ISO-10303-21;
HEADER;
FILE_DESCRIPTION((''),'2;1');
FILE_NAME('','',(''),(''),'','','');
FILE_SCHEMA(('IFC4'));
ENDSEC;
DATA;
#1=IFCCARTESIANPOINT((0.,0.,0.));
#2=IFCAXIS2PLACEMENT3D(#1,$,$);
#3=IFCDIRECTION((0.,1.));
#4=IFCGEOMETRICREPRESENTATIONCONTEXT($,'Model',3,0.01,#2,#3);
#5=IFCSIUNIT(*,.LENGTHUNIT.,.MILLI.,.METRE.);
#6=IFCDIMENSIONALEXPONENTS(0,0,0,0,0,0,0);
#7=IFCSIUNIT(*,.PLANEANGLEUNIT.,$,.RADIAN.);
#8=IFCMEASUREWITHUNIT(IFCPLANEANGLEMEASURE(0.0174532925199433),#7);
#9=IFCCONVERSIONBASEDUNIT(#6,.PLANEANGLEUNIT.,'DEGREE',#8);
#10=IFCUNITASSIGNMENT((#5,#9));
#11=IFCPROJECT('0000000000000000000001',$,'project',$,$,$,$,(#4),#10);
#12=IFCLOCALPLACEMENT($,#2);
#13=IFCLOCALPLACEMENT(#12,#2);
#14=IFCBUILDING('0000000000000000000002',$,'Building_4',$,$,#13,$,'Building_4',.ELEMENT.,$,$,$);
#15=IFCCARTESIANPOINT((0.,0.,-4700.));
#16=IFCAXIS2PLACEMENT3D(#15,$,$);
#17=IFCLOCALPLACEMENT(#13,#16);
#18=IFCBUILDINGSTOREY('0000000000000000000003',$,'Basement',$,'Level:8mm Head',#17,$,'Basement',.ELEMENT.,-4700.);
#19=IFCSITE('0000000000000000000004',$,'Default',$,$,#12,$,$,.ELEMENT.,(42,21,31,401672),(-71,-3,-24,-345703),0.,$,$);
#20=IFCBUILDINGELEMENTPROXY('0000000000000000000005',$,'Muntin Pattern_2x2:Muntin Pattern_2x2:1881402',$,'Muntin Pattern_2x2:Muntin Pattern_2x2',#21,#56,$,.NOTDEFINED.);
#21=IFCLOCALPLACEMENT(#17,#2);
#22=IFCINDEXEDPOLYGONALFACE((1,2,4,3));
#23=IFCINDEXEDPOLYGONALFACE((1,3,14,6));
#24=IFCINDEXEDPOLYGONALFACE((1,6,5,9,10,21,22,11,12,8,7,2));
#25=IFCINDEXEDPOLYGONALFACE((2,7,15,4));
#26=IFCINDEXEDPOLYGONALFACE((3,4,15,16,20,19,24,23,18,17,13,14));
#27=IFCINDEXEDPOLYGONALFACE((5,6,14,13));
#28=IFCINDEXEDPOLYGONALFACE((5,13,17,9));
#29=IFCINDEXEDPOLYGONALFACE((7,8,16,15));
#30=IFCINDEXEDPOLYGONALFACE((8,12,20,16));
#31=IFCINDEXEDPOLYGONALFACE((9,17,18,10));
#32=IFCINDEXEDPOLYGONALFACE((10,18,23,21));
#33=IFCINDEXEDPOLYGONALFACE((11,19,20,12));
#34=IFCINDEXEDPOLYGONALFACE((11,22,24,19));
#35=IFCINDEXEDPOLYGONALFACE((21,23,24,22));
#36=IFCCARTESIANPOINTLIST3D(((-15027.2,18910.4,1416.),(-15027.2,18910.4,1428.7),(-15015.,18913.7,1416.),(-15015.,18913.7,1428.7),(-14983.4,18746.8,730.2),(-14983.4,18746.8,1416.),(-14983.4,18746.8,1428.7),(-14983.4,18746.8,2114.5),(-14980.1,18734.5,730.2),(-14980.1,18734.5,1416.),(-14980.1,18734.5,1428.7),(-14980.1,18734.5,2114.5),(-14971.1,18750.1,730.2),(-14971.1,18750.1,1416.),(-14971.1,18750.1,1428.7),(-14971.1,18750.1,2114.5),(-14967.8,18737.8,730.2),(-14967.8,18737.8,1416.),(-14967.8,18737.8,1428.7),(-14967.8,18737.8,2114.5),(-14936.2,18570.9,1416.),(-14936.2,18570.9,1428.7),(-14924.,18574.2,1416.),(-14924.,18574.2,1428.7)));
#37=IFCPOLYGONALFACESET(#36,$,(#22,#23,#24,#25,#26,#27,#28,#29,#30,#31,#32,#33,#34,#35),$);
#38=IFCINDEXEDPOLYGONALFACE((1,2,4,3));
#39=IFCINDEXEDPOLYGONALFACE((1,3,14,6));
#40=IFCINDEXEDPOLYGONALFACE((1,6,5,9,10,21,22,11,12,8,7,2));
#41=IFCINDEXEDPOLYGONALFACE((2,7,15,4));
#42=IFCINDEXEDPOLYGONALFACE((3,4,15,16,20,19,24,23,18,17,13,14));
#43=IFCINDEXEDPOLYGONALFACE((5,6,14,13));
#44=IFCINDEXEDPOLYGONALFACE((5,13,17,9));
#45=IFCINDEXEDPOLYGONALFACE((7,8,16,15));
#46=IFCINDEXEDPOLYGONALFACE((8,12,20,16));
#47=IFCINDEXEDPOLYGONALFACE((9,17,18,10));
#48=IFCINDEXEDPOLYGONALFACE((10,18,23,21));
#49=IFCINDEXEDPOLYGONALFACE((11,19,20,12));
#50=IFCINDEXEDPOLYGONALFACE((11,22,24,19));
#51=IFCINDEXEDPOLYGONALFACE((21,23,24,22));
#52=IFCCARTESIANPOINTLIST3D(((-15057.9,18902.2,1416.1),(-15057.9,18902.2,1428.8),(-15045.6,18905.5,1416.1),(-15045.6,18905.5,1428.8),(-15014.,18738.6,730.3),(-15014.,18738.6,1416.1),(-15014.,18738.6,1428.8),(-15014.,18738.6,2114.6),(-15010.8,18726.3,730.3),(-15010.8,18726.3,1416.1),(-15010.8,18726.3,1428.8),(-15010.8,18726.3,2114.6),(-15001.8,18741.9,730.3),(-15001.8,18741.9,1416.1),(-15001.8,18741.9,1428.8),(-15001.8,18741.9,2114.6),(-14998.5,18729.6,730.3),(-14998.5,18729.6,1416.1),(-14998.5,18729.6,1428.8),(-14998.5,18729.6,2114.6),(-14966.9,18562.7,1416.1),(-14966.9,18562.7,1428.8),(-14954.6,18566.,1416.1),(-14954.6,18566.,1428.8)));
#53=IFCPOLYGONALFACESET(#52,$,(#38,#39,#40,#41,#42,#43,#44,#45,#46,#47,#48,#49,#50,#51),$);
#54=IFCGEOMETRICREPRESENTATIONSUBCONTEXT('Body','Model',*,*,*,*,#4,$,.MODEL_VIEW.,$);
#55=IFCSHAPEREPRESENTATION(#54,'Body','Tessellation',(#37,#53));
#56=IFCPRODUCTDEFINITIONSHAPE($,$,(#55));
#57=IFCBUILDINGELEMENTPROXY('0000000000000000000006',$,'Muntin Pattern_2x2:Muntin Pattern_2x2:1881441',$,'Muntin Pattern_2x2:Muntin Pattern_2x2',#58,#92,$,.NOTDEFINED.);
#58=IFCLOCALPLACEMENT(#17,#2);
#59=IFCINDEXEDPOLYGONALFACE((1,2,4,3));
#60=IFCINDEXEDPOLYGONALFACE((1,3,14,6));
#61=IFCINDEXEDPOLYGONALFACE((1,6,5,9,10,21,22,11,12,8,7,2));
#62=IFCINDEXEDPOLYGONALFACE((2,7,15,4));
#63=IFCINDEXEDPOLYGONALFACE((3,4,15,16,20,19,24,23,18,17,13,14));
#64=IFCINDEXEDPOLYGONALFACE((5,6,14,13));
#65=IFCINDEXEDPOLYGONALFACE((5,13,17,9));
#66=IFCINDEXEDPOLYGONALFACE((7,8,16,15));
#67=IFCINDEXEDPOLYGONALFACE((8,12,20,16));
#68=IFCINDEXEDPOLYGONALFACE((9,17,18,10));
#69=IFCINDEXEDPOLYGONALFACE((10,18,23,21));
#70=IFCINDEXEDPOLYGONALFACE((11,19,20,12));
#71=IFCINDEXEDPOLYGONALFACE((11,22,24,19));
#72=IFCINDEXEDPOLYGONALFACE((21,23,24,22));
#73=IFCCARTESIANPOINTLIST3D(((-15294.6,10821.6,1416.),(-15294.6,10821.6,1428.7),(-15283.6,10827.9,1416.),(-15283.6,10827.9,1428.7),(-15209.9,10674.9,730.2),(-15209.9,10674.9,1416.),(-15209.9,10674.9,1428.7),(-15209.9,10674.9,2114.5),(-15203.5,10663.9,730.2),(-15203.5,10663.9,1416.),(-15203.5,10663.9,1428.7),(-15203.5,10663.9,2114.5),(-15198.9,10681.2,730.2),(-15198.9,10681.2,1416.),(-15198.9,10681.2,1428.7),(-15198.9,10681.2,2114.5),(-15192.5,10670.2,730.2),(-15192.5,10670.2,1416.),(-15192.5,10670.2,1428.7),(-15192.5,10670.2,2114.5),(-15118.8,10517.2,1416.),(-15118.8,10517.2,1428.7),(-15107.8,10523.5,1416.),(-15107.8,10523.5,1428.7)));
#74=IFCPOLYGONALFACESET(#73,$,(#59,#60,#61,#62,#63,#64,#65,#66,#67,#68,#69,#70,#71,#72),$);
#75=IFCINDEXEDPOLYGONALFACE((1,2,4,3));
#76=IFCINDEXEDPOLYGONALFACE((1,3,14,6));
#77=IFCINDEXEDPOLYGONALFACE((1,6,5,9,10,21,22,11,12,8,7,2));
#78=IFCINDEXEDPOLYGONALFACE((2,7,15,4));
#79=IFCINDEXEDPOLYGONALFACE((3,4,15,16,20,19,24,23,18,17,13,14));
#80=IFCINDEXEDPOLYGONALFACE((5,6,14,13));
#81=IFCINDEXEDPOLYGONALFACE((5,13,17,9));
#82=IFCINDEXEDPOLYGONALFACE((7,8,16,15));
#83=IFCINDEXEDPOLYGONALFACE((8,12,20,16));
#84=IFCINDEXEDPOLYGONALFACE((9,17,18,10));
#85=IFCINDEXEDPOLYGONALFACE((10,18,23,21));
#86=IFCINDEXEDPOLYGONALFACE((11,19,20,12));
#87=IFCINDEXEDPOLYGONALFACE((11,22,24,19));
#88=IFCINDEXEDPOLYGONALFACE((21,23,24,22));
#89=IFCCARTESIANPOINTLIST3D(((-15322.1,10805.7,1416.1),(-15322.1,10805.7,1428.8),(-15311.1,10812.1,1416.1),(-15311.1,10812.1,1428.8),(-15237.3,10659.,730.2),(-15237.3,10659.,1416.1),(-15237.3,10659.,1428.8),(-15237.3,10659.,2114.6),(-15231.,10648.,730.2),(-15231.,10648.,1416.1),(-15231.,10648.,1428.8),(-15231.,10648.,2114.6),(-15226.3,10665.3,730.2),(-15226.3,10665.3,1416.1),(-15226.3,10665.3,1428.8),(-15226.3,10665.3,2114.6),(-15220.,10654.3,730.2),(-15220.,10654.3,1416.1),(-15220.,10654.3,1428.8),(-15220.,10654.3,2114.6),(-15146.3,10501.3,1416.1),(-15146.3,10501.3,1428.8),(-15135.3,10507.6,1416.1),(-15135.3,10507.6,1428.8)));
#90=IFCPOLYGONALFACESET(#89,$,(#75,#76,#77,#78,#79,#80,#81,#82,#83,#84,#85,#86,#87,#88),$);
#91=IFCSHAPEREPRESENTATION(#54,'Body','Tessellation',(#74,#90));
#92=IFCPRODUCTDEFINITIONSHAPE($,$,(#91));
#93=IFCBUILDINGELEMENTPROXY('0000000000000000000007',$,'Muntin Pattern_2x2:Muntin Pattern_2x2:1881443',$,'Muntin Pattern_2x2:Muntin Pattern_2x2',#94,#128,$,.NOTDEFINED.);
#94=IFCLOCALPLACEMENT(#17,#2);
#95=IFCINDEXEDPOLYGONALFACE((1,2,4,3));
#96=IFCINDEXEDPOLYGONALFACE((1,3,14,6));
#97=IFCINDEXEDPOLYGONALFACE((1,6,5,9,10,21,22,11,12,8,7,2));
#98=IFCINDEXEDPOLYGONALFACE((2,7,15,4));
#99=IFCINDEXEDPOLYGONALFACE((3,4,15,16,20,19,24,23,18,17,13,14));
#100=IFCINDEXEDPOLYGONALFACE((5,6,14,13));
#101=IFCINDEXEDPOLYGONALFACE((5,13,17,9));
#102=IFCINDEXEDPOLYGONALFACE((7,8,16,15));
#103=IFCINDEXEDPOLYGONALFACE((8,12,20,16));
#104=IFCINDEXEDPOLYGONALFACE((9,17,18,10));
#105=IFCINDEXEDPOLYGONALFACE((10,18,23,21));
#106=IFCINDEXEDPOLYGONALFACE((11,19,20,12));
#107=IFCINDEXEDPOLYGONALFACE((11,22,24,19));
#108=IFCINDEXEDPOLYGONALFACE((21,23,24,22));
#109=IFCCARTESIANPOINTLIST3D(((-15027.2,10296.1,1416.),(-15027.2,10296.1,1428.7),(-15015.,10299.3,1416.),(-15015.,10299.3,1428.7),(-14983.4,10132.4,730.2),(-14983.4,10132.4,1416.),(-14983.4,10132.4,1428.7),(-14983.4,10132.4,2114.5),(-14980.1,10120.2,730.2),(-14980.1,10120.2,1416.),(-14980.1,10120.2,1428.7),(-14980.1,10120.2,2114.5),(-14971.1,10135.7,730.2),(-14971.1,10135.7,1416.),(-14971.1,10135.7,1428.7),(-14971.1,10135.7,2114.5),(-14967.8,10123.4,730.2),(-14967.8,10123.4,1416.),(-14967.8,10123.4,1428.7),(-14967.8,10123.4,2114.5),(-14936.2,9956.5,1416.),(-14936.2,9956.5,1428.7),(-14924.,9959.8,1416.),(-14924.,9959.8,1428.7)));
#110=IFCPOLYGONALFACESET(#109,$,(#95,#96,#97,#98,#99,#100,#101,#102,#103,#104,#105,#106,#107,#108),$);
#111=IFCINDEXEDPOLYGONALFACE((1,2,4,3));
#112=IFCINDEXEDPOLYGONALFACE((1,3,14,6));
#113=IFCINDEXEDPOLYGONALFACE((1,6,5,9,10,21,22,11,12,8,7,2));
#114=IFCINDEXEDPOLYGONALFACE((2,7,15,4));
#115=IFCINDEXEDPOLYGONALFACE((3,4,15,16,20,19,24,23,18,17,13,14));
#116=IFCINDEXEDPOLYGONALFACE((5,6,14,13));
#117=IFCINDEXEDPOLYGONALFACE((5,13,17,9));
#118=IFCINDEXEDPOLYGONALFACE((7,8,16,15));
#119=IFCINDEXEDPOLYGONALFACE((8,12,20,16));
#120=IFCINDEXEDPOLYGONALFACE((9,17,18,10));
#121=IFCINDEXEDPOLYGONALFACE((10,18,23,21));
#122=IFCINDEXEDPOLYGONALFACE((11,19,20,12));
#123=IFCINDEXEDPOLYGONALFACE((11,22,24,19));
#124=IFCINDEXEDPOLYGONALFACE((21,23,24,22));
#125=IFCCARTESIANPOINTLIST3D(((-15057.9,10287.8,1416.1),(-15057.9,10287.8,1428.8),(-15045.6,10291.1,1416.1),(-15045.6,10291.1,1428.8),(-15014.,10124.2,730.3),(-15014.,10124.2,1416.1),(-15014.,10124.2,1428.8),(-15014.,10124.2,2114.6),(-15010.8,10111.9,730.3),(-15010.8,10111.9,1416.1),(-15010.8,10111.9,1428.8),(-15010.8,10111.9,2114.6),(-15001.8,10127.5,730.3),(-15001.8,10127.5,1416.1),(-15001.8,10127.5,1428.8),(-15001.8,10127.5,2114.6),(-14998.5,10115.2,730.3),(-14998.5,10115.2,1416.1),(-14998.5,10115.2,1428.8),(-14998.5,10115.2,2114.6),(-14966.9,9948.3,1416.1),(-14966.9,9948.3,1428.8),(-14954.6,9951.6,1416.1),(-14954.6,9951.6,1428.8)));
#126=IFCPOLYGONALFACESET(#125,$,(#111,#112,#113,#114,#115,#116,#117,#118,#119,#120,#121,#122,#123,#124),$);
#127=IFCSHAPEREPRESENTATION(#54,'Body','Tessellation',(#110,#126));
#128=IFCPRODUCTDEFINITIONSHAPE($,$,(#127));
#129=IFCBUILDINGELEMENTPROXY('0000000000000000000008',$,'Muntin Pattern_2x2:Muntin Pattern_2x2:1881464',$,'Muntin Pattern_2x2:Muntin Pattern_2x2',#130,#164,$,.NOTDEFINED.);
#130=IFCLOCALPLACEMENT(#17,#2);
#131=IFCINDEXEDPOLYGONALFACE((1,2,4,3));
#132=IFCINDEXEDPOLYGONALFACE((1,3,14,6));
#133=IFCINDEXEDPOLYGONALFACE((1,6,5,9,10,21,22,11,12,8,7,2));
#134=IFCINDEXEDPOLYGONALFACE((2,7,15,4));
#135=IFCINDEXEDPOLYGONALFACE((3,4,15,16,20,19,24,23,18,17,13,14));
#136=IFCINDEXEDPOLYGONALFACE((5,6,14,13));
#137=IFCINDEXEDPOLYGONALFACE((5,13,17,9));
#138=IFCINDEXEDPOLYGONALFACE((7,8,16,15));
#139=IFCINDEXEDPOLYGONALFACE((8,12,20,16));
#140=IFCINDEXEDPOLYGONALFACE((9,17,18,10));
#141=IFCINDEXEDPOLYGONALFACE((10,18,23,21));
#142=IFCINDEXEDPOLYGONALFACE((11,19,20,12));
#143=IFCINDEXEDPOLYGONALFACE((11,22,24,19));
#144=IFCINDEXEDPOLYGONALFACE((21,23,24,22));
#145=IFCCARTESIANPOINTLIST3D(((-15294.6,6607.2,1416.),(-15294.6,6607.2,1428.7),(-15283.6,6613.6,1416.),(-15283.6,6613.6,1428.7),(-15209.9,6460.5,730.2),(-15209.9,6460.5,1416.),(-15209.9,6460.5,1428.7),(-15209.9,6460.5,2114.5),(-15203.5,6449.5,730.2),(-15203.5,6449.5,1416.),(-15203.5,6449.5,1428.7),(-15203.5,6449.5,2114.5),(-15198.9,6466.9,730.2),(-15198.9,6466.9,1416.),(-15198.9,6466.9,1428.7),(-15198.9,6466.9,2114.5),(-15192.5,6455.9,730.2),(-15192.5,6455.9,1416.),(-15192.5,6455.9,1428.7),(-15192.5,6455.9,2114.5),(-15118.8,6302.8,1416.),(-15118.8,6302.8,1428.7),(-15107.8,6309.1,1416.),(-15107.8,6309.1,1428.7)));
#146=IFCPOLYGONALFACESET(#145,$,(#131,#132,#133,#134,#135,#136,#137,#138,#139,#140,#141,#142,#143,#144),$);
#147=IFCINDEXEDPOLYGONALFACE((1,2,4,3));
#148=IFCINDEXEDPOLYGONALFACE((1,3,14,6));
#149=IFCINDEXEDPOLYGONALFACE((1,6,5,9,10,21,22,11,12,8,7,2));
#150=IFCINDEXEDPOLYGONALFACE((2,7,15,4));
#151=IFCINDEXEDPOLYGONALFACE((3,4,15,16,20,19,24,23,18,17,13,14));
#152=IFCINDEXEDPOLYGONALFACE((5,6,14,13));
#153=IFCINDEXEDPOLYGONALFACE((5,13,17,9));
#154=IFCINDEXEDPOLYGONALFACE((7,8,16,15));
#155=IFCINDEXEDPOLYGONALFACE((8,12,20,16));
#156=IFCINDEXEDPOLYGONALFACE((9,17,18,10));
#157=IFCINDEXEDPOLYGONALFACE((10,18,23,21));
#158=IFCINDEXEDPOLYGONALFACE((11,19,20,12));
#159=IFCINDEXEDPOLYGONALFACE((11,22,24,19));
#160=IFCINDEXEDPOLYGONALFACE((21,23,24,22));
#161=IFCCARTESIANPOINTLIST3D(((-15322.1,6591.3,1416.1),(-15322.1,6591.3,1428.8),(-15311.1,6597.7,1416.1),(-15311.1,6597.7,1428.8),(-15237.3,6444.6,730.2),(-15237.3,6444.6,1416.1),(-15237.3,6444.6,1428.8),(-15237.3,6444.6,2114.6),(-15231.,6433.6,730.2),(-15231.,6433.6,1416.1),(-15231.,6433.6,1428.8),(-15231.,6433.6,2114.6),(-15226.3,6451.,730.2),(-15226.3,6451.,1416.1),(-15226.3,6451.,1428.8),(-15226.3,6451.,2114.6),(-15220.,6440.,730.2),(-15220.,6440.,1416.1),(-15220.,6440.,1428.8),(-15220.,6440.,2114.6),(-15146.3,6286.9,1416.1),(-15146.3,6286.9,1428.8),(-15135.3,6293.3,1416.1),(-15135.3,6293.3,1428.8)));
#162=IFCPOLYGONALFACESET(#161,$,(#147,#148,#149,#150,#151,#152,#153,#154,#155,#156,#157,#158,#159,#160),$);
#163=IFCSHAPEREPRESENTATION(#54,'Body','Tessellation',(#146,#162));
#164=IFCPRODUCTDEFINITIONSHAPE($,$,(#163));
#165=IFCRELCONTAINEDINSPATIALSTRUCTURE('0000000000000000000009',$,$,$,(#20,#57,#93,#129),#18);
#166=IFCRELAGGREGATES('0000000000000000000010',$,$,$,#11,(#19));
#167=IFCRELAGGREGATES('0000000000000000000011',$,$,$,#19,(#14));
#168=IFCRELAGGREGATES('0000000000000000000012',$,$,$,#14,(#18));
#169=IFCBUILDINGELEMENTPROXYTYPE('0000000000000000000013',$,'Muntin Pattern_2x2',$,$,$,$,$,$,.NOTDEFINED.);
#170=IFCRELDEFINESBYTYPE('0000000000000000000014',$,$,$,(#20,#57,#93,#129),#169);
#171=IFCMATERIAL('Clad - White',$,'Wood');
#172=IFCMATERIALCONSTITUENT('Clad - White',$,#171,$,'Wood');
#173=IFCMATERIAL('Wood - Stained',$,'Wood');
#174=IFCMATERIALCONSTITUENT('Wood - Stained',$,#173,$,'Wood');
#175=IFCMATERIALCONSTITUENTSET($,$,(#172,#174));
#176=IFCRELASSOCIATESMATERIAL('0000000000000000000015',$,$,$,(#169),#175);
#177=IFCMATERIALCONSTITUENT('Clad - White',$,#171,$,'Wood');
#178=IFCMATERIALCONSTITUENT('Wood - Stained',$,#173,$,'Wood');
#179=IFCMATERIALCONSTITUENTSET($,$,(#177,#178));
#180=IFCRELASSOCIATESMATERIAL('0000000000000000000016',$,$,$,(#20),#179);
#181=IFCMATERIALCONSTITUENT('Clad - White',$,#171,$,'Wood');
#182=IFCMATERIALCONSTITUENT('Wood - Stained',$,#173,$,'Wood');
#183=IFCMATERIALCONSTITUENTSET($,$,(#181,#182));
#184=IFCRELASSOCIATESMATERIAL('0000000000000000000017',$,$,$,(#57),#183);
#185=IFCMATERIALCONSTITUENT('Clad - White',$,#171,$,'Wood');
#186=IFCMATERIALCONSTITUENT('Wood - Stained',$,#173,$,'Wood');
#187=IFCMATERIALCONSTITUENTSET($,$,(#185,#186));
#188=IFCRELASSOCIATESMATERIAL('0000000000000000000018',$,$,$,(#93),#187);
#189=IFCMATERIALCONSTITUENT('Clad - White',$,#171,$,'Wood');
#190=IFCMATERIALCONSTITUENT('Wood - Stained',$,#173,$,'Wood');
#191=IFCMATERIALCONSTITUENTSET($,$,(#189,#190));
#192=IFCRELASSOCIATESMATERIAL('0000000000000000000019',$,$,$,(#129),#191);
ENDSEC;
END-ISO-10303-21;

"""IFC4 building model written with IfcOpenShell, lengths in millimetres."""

from ifc_helpers import new_model, entity, si_unit, converted_unit, direction, frame, origin, place, context, subcontext, project, spatial, indexed_curve, outline, extrude, source, transform, mapped, material, constituent, constituent_set, type_object, type_shapes, element, save


model = new_model("IFC4")

# Units and contexts
model_context = context("Model", 3, precision=0.01, world=origin(), true_north=direction((0.0, 1.0)))
body_context = subcontext(model_context, "Body", "Model", "MODEL_VIEW")
ifc_project = project(units=[si_unit("LENGTHUNIT", "METRE", prefix="MILLI"), converted_unit("PLANEANGLEUNIT", "DEGREE", entity("IfcPlaneAngleMeasure", 0.0174532925199433), si_unit("PLANEANGLEUNIT", "RADIAN"), dimensions=[0, 0, 0, 0, 0, 0, 0])], contexts=[model_context])

# Site, building, storey
site_placement = place(None, origin())
site = spatial("IfcSite", under=ifc_project, at=site_placement, Name="Default", CompositionType="ELEMENT", RefLatitude=(42, 21, 31, 401672), RefLongitude=(-71, -3, -24, -345703), RefElevation=0.0)
building_placement = place(site_placement, origin())
building = spatial("IfcBuilding", under=site, at=building_placement, Name="Building_4", LongName="Building_4", CompositionType="ELEMENT")
storey_placement = place(building_placement, frame((0.0, 0.0, -4700.0)))
storey = spatial("IfcBuildingStorey", under=building, at=storey_placement, Name="Basement", ObjectType="Level:8mm Head", LongName="Basement", CompositionType="ELEMENT", Elevation=-4700.0)

# Building element proxies
ifc_material_1 = material(Name="Clad - White", Category="Wood")
ifc_material_2 = material(Name="Wood - Stained", Category="Wood")
ifc_constituent_1 = constituent(ifc_material_1, Name="Clad - White", Category="Wood")
ifc_constituent_2 = constituent(ifc_material_2, Name="Wood - Stained", Category="Wood")
ifc_constituent_set_1 = constituent_set(constituents=[ifc_constituent_1, ifc_constituent_2])
building_element_proxy_type_1 = type_object("IfcBuildingElementProxyType", Name="Muntin Pattern_2x2", PredefinedType="NOTDEFINED", material=ifc_constituent_set_1)
shared_shape_1 = source(origin(), body_context, "Body", "SweptSolid", [
    extrude(outline(indexed_curve([(6.4, -6.4), (692.1, -6.4), (692.1, 6.3), (6.4, 6.3), (6.4, 175.8), (-6.3, 175.8), (-6.3, 6.3), (-692.2, 6.3), (-692.2, -6.4), (-6.3, -6.4), (-6.3, -175.8), (6.4, -175.8), (6.4, -6.4)], self_intersect=False)), frame((0.0, 9.5, 692.1), z_axis=(0.0, 1.0, 0.0), x_axis=(0.0, 0.0, 1.0)), (0.0, 0.0, 1.0), 12.7),
    extrude(outline(indexed_curve([(6.4, -6.4), (692.1, -6.4), (692.1, 6.3), (6.4, 6.3), (6.4, 175.8), (-6.3, 175.8), (-6.3, 6.3), (-692.2, 6.3), (-692.2, -6.4), (-6.3, -6.4), (-6.3, -175.8), (6.4, -175.8), (6.4, -6.4)], self_intersect=False)), frame((0.0, -22.2, 692.2), z_axis=(0.0, 1.0, 0.0), x_axis=(0.0, 0.0, 1.0)), (0.0, 0.0, 1.0), 12.7),
])
type_shapes(building_element_proxy_type_1, [shared_shape_1])
ifc_constituent_3 = constituent(ifc_material_1, Name="Clad - White", Category="Wood")
ifc_constituent_4 = constituent(ifc_material_2, Name="Wood - Stained", Category="Wood")
ifc_constituent_set_2 = constituent_set(constituents=[ifc_constituent_3, ifc_constituent_4])
proxy_1_placement = place(storey_placement, frame((-14990.9, 18738.2, 730.3), z_axis=(0.0, 0.0, 1.0), x_axis=(0.258819, -0.965926, 0.0)))
element("IfcBuildingElementProxy", 1, at=proxy_1_placement, inside=storey, type_object=building_element_proxy_type_1, material=ifc_constituent_set_2, Name="Muntin Pattern_2x2:Muntin Pattern_2x2:1881402", ObjectType="Muntin Pattern_2x2:Muntin Pattern_2x2", PredefinedType="NOTDEFINED", context=body_context, shape_type="MappedRepresentation", body=[
    mapped(shared_shape_1, transform((0.0, 0.0, 0.0), scale=1.0)),
])
ifc_constituent_5 = constituent(ifc_material_1, Name="Clad - White", Category="Wood")
ifc_constituent_6 = constituent(ifc_material_2, Name="Wood - Stained", Category="Wood")
ifc_constituent_set_3 = constituent_set(constituents=[ifc_constituent_5, ifc_constituent_6])
proxy_2_placement = place(storey_placement, frame((-15214.9, 10664.6, 730.2), z_axis=(0.0, 0.0, 1.0), x_axis=(0.5, -0.866025, 0.0)))
element("IfcBuildingElementProxy", 2, at=proxy_2_placement, inside=storey, type_object=building_element_proxy_type_1, material=ifc_constituent_set_3, Name="Muntin Pattern_2x2:Muntin Pattern_2x2:1881441", ObjectType="Muntin Pattern_2x2:Muntin Pattern_2x2", PredefinedType="NOTDEFINED", context=body_context, shape_type="MappedRepresentation", body=[
    mapped(shared_shape_1, transform((0.0, 0.0, 0.0), scale=1.0)),
])
ifc_constituent_7 = constituent(ifc_material_1, Name="Clad - White", Category="Wood")
ifc_constituent_8 = constituent(ifc_material_2, Name="Wood - Stained", Category="Wood")
ifc_constituent_set_4 = constituent_set(constituents=[ifc_constituent_7, ifc_constituent_8])
proxy_3_placement = place(storey_placement, frame((-14990.9, 10123.8, 730.3), z_axis=(0.0, 0.0, 1.0), x_axis=(0.258819, -0.965926, 0.0)))
element("IfcBuildingElementProxy", 3, at=proxy_3_placement, inside=storey, type_object=building_element_proxy_type_1, material=ifc_constituent_set_4, Name="Muntin Pattern_2x2:Muntin Pattern_2x2:1881443", ObjectType="Muntin Pattern_2x2:Muntin Pattern_2x2", PredefinedType="NOTDEFINED", context=body_context, shape_type="MappedRepresentation", body=[
    mapped(shared_shape_1, transform((0.0, 0.0, 0.0), scale=1.0)),
])
ifc_constituent_9 = constituent(ifc_material_1, Name="Clad - White", Category="Wood")
ifc_constituent_10 = constituent(ifc_material_2, Name="Wood - Stained", Category="Wood")
ifc_constituent_set_5 = constituent_set(constituents=[ifc_constituent_9, ifc_constituent_10])
proxy_4_placement = place(storey_placement, frame((-15214.9, 6450.2, 730.2), z_axis=(0.0, 0.0, 1.0), x_axis=(0.5, -0.866025, 0.0)))
element("IfcBuildingElementProxy", 4, at=proxy_4_placement, inside=storey, type_object=building_element_proxy_type_1, material=ifc_constituent_set_5, Name="Muntin Pattern_2x2:Muntin Pattern_2x2:1881464", ObjectType="Muntin Pattern_2x2:Muntin Pattern_2x2", PredefinedType="NOTDEFINED", context=body_context, shape_type="MappedRepresentation", body=[
    mapped(shared_shape_1, transform((0.0, 0.0, 0.0), scale=1.0)),
])

save(model, "model.ifc")
